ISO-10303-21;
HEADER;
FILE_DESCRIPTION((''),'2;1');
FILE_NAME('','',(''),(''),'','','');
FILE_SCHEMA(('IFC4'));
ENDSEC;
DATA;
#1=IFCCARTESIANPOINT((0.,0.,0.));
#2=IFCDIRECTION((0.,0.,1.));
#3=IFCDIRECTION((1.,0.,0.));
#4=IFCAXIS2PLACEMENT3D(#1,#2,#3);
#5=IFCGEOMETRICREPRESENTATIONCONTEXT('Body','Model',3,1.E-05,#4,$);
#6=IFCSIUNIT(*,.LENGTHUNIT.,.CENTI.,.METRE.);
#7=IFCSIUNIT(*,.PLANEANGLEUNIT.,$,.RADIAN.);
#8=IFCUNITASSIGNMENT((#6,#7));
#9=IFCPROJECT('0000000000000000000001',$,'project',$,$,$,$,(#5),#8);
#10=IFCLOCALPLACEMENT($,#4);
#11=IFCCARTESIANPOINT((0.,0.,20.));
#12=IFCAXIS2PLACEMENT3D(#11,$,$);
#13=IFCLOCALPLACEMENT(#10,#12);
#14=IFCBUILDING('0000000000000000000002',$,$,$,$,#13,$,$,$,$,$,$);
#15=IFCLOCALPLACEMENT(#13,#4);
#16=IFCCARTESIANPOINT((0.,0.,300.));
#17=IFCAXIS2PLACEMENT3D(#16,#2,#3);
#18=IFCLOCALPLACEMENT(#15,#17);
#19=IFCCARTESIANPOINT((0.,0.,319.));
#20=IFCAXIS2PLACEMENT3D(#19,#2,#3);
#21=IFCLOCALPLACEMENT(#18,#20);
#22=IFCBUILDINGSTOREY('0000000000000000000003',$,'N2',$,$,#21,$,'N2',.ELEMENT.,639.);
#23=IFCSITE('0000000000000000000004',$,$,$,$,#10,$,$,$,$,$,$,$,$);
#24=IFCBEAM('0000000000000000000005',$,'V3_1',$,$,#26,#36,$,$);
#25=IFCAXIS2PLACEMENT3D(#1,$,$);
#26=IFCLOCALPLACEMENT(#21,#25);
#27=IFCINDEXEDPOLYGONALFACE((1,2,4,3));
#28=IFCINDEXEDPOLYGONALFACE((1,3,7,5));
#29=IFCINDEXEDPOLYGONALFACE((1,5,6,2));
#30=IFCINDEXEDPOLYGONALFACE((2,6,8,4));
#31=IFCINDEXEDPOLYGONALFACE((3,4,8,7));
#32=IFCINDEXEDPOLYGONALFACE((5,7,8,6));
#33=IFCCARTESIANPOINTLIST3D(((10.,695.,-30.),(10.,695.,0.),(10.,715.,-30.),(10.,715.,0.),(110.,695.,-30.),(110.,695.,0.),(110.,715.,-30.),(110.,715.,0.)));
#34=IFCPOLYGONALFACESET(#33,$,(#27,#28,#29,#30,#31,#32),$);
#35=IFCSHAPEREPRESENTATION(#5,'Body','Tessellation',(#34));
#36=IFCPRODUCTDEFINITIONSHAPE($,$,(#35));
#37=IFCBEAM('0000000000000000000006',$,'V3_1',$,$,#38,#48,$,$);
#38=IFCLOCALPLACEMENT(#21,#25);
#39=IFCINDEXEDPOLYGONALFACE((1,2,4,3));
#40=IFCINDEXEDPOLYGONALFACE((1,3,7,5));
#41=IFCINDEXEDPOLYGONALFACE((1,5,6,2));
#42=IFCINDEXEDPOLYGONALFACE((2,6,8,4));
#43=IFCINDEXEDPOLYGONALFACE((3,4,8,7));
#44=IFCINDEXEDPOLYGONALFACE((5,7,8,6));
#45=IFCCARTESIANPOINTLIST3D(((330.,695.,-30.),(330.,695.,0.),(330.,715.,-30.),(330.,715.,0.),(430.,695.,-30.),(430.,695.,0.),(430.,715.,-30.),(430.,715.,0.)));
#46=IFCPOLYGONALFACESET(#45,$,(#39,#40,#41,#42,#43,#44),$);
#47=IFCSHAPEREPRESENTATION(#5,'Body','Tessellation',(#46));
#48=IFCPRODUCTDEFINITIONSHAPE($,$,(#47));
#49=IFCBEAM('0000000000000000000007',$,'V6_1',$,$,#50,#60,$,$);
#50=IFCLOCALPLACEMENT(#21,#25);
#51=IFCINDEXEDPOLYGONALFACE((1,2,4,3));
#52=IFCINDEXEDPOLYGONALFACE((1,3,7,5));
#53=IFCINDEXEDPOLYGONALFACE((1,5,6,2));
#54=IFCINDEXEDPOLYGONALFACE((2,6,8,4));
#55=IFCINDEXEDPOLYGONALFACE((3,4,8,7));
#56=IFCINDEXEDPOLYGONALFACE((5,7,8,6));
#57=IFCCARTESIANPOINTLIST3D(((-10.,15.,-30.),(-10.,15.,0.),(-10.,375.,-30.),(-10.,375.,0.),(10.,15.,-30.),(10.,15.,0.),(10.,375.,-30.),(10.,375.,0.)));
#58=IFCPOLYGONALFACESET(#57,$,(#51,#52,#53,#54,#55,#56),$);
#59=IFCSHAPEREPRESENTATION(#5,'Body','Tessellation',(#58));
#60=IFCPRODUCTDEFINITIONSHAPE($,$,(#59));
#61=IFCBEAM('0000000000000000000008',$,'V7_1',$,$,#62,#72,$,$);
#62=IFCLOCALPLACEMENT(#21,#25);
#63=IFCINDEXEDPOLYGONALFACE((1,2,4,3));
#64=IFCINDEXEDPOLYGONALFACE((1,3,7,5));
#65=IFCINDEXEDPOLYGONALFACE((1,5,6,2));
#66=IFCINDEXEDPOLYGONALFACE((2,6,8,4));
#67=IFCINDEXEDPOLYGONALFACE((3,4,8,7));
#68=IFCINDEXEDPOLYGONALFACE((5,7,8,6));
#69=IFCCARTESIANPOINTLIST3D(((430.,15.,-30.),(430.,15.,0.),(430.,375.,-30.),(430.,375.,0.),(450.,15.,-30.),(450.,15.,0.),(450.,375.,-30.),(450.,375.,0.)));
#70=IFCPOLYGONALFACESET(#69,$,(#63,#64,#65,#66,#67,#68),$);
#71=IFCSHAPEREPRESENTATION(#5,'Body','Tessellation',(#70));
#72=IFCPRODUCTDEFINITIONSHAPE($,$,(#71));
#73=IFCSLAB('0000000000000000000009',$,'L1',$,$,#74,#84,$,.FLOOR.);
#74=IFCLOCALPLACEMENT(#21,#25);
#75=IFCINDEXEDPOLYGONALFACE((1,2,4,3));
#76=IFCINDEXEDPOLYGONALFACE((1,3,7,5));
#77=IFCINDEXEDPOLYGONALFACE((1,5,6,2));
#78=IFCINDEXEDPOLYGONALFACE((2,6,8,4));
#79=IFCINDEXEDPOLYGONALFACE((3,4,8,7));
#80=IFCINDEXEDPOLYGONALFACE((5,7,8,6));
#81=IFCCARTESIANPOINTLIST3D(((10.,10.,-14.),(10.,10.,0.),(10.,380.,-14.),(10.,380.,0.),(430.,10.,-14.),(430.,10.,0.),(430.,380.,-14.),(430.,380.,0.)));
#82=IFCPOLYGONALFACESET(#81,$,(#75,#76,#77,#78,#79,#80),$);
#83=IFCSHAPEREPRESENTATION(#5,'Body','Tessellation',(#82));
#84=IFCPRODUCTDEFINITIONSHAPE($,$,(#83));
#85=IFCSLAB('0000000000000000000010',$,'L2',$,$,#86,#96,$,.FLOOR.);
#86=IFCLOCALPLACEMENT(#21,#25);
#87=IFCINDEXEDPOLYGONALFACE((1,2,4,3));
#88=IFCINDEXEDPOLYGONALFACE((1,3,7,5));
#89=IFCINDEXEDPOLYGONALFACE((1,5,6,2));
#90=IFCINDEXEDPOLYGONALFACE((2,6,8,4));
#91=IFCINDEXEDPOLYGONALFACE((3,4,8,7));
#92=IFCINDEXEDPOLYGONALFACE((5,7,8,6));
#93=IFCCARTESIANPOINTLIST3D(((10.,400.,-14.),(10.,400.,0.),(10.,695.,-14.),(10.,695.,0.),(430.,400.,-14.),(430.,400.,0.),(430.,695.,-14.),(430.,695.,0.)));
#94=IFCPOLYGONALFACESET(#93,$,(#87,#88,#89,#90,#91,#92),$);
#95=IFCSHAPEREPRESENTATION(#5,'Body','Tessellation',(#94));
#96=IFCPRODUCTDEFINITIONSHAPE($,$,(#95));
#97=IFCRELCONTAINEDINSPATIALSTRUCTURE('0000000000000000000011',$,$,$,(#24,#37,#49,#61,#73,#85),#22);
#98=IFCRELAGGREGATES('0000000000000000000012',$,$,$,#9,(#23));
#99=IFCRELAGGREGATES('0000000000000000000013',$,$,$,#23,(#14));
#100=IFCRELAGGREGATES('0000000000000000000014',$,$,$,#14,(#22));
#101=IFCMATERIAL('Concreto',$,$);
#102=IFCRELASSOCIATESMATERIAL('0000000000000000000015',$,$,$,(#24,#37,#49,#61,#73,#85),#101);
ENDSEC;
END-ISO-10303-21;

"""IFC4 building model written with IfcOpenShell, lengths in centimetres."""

from ifc_helpers import new_model, si_unit, frame, origin_with_axes, origin_2d_with_axis, place, context, project, spatial, polyline, rectangle, outline, extrude, material, element, save


model = new_model("IFC4")

# Units and contexts
model_context = context("Model", 3, precision=1e-05, world=origin_with_axes(), identifier="Body")
ifc_project = project(units=[si_unit("LENGTHUNIT", "METRE", prefix="CENTI"), si_unit("PLANEANGLEUNIT", "RADIAN")], contexts=[model_context])

# Site, building, storey
site_placement = place(None, origin_with_axes())
site = spatial("IfcSite", under=ifc_project, at=site_placement)
building_placement = place(site_placement, frame((0.0, 0.0, 20.0)))
building = spatial("IfcBuilding", under=site, at=building_placement)
placement_1 = place(building_placement, origin_with_axes())
placement_2 = place(placement_1, frame((0.0, 0.0, 300.0), z_axis=(0.0, 0.0, 1.0), x_axis=(1.0, 0.0, 0.0)))
storey_placement = place(placement_2, frame((0.0, 0.0, 319.0), z_axis=(0.0, 0.0, 1.0), x_axis=(1.0, 0.0, 0.0)))
storey = spatial("IfcBuildingStorey", under=building, at=storey_placement, Name="N2", LongName="N2", CompositionType="ELEMENT", Elevation=639.0)

# Shared definitions
ifc_material = material(Name="Concreto")

# Beams
for number, where, z_axis, x_axis, name in (
    (1, (60.0, 705.0, 0.0), (0.0, 0.0, 1.0), (1.0, 0.0, 0.0), "V3_1"),
    (2, (380.0, 705.0, 0.0), (0.0, 0.0, 1.0), (1.0, 0.0, 0.0), "V3_1"),
):
    element("IfcBeam", number, at=place(storey_placement, frame(where, z_axis=z_axis, x_axis=x_axis)), inside=storey, material=ifc_material, Name=name, context=model_context, shape_type="SolidModel", body=[
        extrude(rectangle(XDim=20.0, YDim=30.0, at=origin_2d_with_axis()), frame((-50.0, 0.0, -15.0), z_axis=(1.0, 0.0, 0.0), x_axis=(0.0, 1.0, 0.0)), (0.0, 0.0, 1.0), 100.0),
    ])
beam_1_placement = place(storey_placement, frame((0.0, 195.0, 0.0), z_axis=(0.0, 0.0, 1.0), x_axis=(1.0, 0.0, 0.0)))
element("IfcBeam", 3, at=beam_1_placement, inside=storey, material=ifc_material, Name="V6_1", context=model_context, shape_type="SolidModel", body=[
    extrude(rectangle(XDim=20.0, YDim=30.0, at=origin_2d_with_axis()), frame((0.0, -180.0, -15.0), z_axis=(0.0, 1.0, 0.0), x_axis=(-1.0, 0.0, 0.0)), (0.0, 0.0, 1.0), 360.0),
])
beam_2_placement = place(storey_placement, frame((440.0, 195.0, 0.0), z_axis=(0.0, 0.0, 1.0), x_axis=(1.0, 0.0, 0.0)))
element("IfcBeam", 4, at=beam_2_placement, inside=storey, material=ifc_material, Name="V7_1", context=model_context, shape_type="SolidModel", body=[
    extrude(rectangle(XDim=20.0, YDim=30.0, at=origin_2d_with_axis()), frame((0.0, -180.0, -15.0), z_axis=(0.0, 1.0, 0.0), x_axis=(1.0, 0.0, 0.0)), (0.0, 0.0, 1.0), 360.0),
])

# Slabs
slab_1_placement = place(storey_placement, frame((220.0, 195.0, 0.0), z_axis=(0.0, 0.0, 1.0), x_axis=(1.0, 0.0, 0.0)))
element("IfcSlab", 5, at=slab_1_placement, inside=storey, material=ifc_material, Name="L1", PredefinedType="FLOOR", context=model_context, shape_type="SolidModel", body=[
    extrude(outline(polyline([(210.0, 185.0), (-210.0, 185.0), (-210.0, -185.0), (210.0, -185.0), (210.0, 185.0), (210.0, 185.0)])), frame((0.0, 0.0, -14.0), z_axis=(0.0, 0.0, 1.0), x_axis=(1.0, 0.0, 0.0)), (0.0, 0.0, 1.0), 14.0),
])
slab_2_placement = place(storey_placement, frame((220.0, 547.5, 0.0), z_axis=(0.0, 0.0, 1.0), x_axis=(1.0, 0.0, 0.0)))
element("IfcSlab", 6, at=slab_2_placement, inside=storey, material=ifc_material, Name="L2", PredefinedType="FLOOR", context=model_context, shape_type="SolidModel", body=[
    extrude(outline(polyline([(210.0, 147.5), (-210.0, 147.5), (-210.0, -147.5), (210.0, -147.5), (210.0, 147.5), (210.0, 147.5)])), frame((0.0, 0.0, -14.0), z_axis=(0.0, 0.0, 1.0), x_axis=(1.0, 0.0, 0.0)), (0.0, 0.0, 1.0), 14.0),
])

save(model, "model.ifc")
